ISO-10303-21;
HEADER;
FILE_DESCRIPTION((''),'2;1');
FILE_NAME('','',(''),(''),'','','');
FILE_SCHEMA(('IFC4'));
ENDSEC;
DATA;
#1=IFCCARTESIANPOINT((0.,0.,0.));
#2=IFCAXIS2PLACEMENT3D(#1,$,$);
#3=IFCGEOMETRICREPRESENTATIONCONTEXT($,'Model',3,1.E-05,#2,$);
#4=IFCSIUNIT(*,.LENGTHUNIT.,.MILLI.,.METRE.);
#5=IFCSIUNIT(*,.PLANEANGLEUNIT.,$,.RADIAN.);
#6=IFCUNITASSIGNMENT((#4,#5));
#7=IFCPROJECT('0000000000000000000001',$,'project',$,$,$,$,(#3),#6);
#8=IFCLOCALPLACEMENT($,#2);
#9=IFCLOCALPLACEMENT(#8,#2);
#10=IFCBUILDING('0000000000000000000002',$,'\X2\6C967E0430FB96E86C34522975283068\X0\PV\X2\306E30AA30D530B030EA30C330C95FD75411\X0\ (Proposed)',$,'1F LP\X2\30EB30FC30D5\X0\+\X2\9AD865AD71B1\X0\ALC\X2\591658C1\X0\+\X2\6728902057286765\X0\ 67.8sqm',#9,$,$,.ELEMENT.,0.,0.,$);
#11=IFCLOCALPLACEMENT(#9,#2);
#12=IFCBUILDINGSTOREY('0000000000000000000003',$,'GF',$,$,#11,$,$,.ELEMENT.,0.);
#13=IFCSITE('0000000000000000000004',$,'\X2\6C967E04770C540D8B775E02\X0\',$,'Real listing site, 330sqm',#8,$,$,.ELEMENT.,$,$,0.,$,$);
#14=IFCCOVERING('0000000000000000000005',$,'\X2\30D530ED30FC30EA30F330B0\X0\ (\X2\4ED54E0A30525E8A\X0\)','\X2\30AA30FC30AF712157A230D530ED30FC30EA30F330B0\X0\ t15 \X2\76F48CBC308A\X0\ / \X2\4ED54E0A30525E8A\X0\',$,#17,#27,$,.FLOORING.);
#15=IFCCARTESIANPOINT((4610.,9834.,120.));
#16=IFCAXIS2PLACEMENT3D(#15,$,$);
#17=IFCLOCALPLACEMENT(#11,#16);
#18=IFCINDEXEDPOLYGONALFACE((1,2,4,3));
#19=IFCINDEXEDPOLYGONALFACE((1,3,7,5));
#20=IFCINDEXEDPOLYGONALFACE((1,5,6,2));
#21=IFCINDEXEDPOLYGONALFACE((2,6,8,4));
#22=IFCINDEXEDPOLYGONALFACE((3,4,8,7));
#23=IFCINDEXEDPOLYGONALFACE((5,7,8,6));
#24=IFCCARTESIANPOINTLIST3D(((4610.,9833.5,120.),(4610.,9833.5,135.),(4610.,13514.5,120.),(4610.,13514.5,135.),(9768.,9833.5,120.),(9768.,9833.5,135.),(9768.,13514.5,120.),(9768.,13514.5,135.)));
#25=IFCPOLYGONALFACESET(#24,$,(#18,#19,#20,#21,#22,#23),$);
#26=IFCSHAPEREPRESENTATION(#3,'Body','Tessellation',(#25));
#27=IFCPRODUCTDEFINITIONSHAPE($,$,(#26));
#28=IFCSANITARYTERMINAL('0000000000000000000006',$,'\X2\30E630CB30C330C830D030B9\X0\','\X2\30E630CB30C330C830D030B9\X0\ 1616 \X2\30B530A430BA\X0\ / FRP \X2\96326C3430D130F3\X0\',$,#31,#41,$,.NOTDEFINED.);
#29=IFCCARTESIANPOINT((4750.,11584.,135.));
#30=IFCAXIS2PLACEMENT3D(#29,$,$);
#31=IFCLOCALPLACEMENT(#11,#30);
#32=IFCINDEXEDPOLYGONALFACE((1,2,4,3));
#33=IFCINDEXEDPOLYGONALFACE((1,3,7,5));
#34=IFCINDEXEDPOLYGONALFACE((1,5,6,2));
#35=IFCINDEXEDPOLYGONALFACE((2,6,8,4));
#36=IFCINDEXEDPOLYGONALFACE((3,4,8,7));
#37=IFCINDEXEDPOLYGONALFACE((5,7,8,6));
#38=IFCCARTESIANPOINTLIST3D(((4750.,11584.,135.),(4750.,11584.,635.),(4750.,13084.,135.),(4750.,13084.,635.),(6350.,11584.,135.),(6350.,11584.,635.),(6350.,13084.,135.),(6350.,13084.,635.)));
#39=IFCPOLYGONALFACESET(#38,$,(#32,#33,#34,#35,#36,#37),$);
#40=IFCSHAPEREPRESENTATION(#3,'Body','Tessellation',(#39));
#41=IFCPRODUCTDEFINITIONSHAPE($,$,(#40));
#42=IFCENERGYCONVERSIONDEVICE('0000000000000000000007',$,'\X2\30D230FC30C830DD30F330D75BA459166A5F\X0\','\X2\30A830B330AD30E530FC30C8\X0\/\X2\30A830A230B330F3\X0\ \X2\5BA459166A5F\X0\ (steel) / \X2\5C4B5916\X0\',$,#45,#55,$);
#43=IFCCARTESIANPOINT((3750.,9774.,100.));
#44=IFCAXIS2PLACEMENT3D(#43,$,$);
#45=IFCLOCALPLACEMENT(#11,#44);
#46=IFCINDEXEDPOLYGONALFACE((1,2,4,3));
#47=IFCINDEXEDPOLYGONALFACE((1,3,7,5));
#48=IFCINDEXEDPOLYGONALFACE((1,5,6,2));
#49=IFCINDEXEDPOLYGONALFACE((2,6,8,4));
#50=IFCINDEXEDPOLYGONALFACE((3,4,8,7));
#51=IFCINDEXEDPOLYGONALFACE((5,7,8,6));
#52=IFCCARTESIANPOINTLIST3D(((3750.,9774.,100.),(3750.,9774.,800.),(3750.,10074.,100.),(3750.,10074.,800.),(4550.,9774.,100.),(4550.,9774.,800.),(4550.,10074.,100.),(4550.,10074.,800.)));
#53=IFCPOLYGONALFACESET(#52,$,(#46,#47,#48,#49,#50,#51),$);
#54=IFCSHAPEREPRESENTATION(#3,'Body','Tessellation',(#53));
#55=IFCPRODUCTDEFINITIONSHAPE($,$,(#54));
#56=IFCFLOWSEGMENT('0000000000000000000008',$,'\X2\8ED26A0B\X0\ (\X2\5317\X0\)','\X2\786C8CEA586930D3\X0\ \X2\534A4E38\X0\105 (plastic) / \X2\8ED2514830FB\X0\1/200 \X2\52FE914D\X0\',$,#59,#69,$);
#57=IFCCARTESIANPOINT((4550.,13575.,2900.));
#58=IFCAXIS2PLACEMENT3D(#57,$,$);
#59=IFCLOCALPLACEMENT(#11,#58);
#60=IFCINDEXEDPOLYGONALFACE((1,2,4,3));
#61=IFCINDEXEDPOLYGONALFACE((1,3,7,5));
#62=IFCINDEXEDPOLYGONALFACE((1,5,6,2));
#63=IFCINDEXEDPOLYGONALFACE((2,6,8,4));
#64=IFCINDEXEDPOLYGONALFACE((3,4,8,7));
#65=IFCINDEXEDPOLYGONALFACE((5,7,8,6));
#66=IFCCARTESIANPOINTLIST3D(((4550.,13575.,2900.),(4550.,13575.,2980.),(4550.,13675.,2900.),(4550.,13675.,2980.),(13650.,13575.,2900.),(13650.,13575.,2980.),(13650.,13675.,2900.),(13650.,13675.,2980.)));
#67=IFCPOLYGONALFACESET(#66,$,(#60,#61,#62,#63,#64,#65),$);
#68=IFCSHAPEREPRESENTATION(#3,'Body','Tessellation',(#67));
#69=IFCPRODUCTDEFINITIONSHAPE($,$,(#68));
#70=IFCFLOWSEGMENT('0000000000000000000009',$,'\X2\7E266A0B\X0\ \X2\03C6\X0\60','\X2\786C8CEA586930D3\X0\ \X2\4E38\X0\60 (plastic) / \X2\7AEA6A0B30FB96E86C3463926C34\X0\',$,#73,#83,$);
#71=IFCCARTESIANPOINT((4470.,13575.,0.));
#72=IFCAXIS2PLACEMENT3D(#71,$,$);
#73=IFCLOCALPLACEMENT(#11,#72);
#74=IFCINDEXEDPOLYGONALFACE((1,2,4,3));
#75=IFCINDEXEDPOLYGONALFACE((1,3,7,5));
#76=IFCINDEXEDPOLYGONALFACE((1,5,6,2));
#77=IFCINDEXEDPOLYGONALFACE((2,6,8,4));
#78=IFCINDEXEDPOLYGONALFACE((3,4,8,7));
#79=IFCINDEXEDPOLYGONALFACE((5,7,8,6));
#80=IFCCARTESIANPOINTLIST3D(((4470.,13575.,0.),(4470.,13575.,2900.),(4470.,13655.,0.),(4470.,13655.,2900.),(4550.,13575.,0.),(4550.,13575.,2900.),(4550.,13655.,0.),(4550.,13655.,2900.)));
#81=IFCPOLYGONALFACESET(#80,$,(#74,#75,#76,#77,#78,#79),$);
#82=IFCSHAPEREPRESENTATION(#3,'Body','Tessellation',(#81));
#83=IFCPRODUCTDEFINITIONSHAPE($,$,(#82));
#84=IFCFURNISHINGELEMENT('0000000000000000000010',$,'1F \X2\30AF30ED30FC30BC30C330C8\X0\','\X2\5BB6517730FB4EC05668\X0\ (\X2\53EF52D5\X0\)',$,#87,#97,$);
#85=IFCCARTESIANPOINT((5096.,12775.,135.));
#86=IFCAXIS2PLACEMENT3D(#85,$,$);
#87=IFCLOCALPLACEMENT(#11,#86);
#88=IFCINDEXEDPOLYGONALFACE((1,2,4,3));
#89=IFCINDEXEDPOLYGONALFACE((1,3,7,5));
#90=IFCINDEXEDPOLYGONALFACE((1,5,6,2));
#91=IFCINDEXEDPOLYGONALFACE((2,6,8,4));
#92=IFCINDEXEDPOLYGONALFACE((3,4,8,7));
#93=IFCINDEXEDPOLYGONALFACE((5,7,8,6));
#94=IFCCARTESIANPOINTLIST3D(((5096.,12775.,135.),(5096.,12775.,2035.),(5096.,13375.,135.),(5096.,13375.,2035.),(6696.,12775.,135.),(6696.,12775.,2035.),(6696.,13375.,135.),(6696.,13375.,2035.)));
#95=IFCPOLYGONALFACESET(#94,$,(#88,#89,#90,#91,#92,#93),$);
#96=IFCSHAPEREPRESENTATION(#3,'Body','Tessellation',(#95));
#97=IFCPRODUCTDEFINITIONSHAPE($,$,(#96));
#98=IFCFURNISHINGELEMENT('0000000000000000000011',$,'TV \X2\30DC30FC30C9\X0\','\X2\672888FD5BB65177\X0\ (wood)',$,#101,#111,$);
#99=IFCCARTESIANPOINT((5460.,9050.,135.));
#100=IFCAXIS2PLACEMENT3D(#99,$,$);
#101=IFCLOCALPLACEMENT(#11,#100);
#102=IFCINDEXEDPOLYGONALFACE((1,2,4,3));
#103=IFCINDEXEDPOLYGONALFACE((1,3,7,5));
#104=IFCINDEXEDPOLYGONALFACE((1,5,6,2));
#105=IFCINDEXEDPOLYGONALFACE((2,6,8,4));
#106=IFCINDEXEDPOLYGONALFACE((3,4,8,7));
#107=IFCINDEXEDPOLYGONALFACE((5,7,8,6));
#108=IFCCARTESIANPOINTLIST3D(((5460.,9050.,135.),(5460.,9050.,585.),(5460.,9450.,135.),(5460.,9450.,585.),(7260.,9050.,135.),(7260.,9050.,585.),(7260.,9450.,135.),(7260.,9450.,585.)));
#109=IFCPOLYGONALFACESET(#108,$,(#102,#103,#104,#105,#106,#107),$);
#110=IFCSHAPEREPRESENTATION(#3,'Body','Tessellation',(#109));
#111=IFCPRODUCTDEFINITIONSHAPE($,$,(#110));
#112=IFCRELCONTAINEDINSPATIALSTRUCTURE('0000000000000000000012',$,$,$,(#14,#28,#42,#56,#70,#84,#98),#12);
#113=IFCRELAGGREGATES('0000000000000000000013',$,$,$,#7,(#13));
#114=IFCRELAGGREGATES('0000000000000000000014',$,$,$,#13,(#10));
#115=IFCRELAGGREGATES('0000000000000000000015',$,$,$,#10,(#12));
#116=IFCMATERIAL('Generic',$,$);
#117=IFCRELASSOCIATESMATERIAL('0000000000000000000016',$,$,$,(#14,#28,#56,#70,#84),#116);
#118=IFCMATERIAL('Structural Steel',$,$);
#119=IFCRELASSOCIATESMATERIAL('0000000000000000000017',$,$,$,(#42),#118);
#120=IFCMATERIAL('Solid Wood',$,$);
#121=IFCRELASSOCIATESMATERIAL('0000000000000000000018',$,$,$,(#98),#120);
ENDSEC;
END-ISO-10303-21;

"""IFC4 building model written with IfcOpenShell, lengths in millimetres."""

from ifc_helpers import new_model, si_unit, frame, frame_2d, origin, place, context, project, spatial, rectangle, extrude, material, element, save


model = new_model("IFC4")

# Units and contexts
model_context = context("Model", 3, precision=1e-05, world=origin())
ifc_project = project(units=[si_unit("LENGTHUNIT", "METRE", prefix="MILLI"), si_unit("PLANEANGLEUNIT", "RADIAN")], contexts=[model_context])

# Site, building, storey
site_placement = place(None, origin())
site = spatial("IfcSite", under=ifc_project, at=site_placement, Name="沖縄県名護市", ObjectType="Real listing site, 330sqm", CompositionType="ELEMENT", RefElevation=0.0)
building_placement = place(site_placement, origin())
building = spatial("IfcBuilding", under=site, at=building_placement, Name="沖縄・雨水利用とPVのオフグリッド志向 (Proposed)", ObjectType="1F LPルーフ+高断熱ALC外壁+木造在来 67.8sqm", CompositionType="ELEMENT", ElevationOfRefHeight=0.0, ElevationOfTerrain=0.0)
storey_placement = place(building_placement, origin())
storey = spatial("IfcBuildingStorey", under=building, at=storey_placement, Name="GF", CompositionType="ELEMENT", Elevation=0.0)

# Shared definitions
ifc_material_1 = material(Name="Solid Wood")

# Shared definitions
ifc_material_2 = material(Name="Structural Steel")

# Covering
ifc_material_3 = material(Name="Generic")
covering_placement = place(storey_placement, frame((4610.0, 9834.0, 120.0)))
element("IfcCovering", 1, at=covering_placement, inside=storey, material=ifc_material_3, Name="フローリング (仕上げ床)", Description="オーク無垢フローリング t15 直貼り / 仕上げ床", PredefinedType="FLOORING", context=model_context, shape_type="SweptSolid", body=[
    extrude(rectangle(XDim=5158.0, YDim=3681.0, at=frame_2d((2579.0, 1840.0))), frame((4610.0, 9834.0, 120.0)), (0.0, 0.0, 1.0), 15.0),
])

# Sanitary terminal
sanitary_terminal_placement = place(storey_placement, frame((4750.0, 11584.0, 135.0)))
element("IfcSanitaryTerminal", 2, at=sanitary_terminal_placement, inside=storey, material=ifc_material_3, Name="ユニットバス", Description="ユニットバス 1616 サイズ / FRP 防水パン", PredefinedType="NOTDEFINED", context=model_context, shape_type="SweptSolid", body=[
    extrude(rectangle(XDim=1600.0, YDim=1500.0, at=frame_2d((800.0, 750.0))), frame((4750.0, 11584.0, 135.0)), (0.0, 0.0, 1.0), 500.0),
])

# Energy conversion device
energy_conversion_device_placement = place(storey_placement, frame((3750.0, 9774.0, 100.0)))
element("IfcEnergyConversionDevice", 3, at=energy_conversion_device_placement, inside=storey, material=ifc_material_2, Name="ヒートポンプ室外機", Description="エコキュート/エアコン 室外機 (steel) / 屋外", context=model_context, shape_type="SweptSolid", body=[
    extrude(rectangle(XDim=800.0, YDim=300.0, at=frame_2d((400.0, 150.0))), frame((3750.0, 9774.0, 100.0)), (0.0, 0.0, 1.0), 700.0),
])

# Flow segments
flow_segment_1_placement = place(storey_placement, frame((4550.0, 13575.0, 2900.0)))
element("IfcFlowSegment", 4, at=flow_segment_1_placement, inside=storey, material=ifc_material_3, Name="軒樋 (北)", Description="硬質塩ビ 半丸105 (plastic) / 軒先・1/200 勾配", context=model_context, shape_type="SweptSolid", body=[
    extrude(rectangle(XDim=9100.0, YDim=100.0, at=frame_2d((4550.0, 50.0))), frame((4550.0, 13575.0, 2900.0)), (0.0, 0.0, 1.0), 80.0),
])
flow_segment_2_placement = place(storey_placement, frame((4470.0, 13575.0, 0.0)))
element("IfcFlowSegment", 5, at=flow_segment_2_placement, inside=storey, material=ifc_material_3, Name="縦樋 φ60", Description="硬質塩ビ 丸60 (plastic) / 竪樋・雨水排水", context=model_context, shape_type="SweptSolid", body=[
    extrude(rectangle(XDim=80.0, YDim=80.0, at=frame_2d((40.0, 40.0))), frame((4470.0, 13575.0, 0.0)), (0.0, 0.0, 1.0), 2900.0),
])

# Furnishing elements
furnishing_1_placement = place(storey_placement, frame((5096.0, 12775.0, 135.0)))
element("IfcFurnishingElement", 6, at=furnishing_1_placement, inside=storey, material=ifc_material_3, Name="1F クローゼット", Description="家具・什器 (可動)", context=model_context, shape_type="SweptSolid", body=[
    extrude(rectangle(XDim=1600.0, YDim=600.0, at=frame_2d((800.0, 300.0))), frame((5096.0, 12775.0, 135.0)), (0.0, 0.0, 1.0), 1900.0),
])
furnishing_2_placement = place(storey_placement, frame((5460.0, 9050.0, 135.0)))
element("IfcFurnishingElement", 7, at=furnishing_2_placement, inside=storey, material=ifc_material_1, Name="TV ボード", Description="木製家具 (wood)", context=model_context, shape_type="SweptSolid", body=[
    extrude(rectangle(XDim=1800.0, YDim=400.0, at=frame_2d((900.0, 200.0))), frame((5460.0, 9050.0, 135.0)), (0.0, 0.0, 1.0), 450.0),
])

save(model, "model.ifc")
